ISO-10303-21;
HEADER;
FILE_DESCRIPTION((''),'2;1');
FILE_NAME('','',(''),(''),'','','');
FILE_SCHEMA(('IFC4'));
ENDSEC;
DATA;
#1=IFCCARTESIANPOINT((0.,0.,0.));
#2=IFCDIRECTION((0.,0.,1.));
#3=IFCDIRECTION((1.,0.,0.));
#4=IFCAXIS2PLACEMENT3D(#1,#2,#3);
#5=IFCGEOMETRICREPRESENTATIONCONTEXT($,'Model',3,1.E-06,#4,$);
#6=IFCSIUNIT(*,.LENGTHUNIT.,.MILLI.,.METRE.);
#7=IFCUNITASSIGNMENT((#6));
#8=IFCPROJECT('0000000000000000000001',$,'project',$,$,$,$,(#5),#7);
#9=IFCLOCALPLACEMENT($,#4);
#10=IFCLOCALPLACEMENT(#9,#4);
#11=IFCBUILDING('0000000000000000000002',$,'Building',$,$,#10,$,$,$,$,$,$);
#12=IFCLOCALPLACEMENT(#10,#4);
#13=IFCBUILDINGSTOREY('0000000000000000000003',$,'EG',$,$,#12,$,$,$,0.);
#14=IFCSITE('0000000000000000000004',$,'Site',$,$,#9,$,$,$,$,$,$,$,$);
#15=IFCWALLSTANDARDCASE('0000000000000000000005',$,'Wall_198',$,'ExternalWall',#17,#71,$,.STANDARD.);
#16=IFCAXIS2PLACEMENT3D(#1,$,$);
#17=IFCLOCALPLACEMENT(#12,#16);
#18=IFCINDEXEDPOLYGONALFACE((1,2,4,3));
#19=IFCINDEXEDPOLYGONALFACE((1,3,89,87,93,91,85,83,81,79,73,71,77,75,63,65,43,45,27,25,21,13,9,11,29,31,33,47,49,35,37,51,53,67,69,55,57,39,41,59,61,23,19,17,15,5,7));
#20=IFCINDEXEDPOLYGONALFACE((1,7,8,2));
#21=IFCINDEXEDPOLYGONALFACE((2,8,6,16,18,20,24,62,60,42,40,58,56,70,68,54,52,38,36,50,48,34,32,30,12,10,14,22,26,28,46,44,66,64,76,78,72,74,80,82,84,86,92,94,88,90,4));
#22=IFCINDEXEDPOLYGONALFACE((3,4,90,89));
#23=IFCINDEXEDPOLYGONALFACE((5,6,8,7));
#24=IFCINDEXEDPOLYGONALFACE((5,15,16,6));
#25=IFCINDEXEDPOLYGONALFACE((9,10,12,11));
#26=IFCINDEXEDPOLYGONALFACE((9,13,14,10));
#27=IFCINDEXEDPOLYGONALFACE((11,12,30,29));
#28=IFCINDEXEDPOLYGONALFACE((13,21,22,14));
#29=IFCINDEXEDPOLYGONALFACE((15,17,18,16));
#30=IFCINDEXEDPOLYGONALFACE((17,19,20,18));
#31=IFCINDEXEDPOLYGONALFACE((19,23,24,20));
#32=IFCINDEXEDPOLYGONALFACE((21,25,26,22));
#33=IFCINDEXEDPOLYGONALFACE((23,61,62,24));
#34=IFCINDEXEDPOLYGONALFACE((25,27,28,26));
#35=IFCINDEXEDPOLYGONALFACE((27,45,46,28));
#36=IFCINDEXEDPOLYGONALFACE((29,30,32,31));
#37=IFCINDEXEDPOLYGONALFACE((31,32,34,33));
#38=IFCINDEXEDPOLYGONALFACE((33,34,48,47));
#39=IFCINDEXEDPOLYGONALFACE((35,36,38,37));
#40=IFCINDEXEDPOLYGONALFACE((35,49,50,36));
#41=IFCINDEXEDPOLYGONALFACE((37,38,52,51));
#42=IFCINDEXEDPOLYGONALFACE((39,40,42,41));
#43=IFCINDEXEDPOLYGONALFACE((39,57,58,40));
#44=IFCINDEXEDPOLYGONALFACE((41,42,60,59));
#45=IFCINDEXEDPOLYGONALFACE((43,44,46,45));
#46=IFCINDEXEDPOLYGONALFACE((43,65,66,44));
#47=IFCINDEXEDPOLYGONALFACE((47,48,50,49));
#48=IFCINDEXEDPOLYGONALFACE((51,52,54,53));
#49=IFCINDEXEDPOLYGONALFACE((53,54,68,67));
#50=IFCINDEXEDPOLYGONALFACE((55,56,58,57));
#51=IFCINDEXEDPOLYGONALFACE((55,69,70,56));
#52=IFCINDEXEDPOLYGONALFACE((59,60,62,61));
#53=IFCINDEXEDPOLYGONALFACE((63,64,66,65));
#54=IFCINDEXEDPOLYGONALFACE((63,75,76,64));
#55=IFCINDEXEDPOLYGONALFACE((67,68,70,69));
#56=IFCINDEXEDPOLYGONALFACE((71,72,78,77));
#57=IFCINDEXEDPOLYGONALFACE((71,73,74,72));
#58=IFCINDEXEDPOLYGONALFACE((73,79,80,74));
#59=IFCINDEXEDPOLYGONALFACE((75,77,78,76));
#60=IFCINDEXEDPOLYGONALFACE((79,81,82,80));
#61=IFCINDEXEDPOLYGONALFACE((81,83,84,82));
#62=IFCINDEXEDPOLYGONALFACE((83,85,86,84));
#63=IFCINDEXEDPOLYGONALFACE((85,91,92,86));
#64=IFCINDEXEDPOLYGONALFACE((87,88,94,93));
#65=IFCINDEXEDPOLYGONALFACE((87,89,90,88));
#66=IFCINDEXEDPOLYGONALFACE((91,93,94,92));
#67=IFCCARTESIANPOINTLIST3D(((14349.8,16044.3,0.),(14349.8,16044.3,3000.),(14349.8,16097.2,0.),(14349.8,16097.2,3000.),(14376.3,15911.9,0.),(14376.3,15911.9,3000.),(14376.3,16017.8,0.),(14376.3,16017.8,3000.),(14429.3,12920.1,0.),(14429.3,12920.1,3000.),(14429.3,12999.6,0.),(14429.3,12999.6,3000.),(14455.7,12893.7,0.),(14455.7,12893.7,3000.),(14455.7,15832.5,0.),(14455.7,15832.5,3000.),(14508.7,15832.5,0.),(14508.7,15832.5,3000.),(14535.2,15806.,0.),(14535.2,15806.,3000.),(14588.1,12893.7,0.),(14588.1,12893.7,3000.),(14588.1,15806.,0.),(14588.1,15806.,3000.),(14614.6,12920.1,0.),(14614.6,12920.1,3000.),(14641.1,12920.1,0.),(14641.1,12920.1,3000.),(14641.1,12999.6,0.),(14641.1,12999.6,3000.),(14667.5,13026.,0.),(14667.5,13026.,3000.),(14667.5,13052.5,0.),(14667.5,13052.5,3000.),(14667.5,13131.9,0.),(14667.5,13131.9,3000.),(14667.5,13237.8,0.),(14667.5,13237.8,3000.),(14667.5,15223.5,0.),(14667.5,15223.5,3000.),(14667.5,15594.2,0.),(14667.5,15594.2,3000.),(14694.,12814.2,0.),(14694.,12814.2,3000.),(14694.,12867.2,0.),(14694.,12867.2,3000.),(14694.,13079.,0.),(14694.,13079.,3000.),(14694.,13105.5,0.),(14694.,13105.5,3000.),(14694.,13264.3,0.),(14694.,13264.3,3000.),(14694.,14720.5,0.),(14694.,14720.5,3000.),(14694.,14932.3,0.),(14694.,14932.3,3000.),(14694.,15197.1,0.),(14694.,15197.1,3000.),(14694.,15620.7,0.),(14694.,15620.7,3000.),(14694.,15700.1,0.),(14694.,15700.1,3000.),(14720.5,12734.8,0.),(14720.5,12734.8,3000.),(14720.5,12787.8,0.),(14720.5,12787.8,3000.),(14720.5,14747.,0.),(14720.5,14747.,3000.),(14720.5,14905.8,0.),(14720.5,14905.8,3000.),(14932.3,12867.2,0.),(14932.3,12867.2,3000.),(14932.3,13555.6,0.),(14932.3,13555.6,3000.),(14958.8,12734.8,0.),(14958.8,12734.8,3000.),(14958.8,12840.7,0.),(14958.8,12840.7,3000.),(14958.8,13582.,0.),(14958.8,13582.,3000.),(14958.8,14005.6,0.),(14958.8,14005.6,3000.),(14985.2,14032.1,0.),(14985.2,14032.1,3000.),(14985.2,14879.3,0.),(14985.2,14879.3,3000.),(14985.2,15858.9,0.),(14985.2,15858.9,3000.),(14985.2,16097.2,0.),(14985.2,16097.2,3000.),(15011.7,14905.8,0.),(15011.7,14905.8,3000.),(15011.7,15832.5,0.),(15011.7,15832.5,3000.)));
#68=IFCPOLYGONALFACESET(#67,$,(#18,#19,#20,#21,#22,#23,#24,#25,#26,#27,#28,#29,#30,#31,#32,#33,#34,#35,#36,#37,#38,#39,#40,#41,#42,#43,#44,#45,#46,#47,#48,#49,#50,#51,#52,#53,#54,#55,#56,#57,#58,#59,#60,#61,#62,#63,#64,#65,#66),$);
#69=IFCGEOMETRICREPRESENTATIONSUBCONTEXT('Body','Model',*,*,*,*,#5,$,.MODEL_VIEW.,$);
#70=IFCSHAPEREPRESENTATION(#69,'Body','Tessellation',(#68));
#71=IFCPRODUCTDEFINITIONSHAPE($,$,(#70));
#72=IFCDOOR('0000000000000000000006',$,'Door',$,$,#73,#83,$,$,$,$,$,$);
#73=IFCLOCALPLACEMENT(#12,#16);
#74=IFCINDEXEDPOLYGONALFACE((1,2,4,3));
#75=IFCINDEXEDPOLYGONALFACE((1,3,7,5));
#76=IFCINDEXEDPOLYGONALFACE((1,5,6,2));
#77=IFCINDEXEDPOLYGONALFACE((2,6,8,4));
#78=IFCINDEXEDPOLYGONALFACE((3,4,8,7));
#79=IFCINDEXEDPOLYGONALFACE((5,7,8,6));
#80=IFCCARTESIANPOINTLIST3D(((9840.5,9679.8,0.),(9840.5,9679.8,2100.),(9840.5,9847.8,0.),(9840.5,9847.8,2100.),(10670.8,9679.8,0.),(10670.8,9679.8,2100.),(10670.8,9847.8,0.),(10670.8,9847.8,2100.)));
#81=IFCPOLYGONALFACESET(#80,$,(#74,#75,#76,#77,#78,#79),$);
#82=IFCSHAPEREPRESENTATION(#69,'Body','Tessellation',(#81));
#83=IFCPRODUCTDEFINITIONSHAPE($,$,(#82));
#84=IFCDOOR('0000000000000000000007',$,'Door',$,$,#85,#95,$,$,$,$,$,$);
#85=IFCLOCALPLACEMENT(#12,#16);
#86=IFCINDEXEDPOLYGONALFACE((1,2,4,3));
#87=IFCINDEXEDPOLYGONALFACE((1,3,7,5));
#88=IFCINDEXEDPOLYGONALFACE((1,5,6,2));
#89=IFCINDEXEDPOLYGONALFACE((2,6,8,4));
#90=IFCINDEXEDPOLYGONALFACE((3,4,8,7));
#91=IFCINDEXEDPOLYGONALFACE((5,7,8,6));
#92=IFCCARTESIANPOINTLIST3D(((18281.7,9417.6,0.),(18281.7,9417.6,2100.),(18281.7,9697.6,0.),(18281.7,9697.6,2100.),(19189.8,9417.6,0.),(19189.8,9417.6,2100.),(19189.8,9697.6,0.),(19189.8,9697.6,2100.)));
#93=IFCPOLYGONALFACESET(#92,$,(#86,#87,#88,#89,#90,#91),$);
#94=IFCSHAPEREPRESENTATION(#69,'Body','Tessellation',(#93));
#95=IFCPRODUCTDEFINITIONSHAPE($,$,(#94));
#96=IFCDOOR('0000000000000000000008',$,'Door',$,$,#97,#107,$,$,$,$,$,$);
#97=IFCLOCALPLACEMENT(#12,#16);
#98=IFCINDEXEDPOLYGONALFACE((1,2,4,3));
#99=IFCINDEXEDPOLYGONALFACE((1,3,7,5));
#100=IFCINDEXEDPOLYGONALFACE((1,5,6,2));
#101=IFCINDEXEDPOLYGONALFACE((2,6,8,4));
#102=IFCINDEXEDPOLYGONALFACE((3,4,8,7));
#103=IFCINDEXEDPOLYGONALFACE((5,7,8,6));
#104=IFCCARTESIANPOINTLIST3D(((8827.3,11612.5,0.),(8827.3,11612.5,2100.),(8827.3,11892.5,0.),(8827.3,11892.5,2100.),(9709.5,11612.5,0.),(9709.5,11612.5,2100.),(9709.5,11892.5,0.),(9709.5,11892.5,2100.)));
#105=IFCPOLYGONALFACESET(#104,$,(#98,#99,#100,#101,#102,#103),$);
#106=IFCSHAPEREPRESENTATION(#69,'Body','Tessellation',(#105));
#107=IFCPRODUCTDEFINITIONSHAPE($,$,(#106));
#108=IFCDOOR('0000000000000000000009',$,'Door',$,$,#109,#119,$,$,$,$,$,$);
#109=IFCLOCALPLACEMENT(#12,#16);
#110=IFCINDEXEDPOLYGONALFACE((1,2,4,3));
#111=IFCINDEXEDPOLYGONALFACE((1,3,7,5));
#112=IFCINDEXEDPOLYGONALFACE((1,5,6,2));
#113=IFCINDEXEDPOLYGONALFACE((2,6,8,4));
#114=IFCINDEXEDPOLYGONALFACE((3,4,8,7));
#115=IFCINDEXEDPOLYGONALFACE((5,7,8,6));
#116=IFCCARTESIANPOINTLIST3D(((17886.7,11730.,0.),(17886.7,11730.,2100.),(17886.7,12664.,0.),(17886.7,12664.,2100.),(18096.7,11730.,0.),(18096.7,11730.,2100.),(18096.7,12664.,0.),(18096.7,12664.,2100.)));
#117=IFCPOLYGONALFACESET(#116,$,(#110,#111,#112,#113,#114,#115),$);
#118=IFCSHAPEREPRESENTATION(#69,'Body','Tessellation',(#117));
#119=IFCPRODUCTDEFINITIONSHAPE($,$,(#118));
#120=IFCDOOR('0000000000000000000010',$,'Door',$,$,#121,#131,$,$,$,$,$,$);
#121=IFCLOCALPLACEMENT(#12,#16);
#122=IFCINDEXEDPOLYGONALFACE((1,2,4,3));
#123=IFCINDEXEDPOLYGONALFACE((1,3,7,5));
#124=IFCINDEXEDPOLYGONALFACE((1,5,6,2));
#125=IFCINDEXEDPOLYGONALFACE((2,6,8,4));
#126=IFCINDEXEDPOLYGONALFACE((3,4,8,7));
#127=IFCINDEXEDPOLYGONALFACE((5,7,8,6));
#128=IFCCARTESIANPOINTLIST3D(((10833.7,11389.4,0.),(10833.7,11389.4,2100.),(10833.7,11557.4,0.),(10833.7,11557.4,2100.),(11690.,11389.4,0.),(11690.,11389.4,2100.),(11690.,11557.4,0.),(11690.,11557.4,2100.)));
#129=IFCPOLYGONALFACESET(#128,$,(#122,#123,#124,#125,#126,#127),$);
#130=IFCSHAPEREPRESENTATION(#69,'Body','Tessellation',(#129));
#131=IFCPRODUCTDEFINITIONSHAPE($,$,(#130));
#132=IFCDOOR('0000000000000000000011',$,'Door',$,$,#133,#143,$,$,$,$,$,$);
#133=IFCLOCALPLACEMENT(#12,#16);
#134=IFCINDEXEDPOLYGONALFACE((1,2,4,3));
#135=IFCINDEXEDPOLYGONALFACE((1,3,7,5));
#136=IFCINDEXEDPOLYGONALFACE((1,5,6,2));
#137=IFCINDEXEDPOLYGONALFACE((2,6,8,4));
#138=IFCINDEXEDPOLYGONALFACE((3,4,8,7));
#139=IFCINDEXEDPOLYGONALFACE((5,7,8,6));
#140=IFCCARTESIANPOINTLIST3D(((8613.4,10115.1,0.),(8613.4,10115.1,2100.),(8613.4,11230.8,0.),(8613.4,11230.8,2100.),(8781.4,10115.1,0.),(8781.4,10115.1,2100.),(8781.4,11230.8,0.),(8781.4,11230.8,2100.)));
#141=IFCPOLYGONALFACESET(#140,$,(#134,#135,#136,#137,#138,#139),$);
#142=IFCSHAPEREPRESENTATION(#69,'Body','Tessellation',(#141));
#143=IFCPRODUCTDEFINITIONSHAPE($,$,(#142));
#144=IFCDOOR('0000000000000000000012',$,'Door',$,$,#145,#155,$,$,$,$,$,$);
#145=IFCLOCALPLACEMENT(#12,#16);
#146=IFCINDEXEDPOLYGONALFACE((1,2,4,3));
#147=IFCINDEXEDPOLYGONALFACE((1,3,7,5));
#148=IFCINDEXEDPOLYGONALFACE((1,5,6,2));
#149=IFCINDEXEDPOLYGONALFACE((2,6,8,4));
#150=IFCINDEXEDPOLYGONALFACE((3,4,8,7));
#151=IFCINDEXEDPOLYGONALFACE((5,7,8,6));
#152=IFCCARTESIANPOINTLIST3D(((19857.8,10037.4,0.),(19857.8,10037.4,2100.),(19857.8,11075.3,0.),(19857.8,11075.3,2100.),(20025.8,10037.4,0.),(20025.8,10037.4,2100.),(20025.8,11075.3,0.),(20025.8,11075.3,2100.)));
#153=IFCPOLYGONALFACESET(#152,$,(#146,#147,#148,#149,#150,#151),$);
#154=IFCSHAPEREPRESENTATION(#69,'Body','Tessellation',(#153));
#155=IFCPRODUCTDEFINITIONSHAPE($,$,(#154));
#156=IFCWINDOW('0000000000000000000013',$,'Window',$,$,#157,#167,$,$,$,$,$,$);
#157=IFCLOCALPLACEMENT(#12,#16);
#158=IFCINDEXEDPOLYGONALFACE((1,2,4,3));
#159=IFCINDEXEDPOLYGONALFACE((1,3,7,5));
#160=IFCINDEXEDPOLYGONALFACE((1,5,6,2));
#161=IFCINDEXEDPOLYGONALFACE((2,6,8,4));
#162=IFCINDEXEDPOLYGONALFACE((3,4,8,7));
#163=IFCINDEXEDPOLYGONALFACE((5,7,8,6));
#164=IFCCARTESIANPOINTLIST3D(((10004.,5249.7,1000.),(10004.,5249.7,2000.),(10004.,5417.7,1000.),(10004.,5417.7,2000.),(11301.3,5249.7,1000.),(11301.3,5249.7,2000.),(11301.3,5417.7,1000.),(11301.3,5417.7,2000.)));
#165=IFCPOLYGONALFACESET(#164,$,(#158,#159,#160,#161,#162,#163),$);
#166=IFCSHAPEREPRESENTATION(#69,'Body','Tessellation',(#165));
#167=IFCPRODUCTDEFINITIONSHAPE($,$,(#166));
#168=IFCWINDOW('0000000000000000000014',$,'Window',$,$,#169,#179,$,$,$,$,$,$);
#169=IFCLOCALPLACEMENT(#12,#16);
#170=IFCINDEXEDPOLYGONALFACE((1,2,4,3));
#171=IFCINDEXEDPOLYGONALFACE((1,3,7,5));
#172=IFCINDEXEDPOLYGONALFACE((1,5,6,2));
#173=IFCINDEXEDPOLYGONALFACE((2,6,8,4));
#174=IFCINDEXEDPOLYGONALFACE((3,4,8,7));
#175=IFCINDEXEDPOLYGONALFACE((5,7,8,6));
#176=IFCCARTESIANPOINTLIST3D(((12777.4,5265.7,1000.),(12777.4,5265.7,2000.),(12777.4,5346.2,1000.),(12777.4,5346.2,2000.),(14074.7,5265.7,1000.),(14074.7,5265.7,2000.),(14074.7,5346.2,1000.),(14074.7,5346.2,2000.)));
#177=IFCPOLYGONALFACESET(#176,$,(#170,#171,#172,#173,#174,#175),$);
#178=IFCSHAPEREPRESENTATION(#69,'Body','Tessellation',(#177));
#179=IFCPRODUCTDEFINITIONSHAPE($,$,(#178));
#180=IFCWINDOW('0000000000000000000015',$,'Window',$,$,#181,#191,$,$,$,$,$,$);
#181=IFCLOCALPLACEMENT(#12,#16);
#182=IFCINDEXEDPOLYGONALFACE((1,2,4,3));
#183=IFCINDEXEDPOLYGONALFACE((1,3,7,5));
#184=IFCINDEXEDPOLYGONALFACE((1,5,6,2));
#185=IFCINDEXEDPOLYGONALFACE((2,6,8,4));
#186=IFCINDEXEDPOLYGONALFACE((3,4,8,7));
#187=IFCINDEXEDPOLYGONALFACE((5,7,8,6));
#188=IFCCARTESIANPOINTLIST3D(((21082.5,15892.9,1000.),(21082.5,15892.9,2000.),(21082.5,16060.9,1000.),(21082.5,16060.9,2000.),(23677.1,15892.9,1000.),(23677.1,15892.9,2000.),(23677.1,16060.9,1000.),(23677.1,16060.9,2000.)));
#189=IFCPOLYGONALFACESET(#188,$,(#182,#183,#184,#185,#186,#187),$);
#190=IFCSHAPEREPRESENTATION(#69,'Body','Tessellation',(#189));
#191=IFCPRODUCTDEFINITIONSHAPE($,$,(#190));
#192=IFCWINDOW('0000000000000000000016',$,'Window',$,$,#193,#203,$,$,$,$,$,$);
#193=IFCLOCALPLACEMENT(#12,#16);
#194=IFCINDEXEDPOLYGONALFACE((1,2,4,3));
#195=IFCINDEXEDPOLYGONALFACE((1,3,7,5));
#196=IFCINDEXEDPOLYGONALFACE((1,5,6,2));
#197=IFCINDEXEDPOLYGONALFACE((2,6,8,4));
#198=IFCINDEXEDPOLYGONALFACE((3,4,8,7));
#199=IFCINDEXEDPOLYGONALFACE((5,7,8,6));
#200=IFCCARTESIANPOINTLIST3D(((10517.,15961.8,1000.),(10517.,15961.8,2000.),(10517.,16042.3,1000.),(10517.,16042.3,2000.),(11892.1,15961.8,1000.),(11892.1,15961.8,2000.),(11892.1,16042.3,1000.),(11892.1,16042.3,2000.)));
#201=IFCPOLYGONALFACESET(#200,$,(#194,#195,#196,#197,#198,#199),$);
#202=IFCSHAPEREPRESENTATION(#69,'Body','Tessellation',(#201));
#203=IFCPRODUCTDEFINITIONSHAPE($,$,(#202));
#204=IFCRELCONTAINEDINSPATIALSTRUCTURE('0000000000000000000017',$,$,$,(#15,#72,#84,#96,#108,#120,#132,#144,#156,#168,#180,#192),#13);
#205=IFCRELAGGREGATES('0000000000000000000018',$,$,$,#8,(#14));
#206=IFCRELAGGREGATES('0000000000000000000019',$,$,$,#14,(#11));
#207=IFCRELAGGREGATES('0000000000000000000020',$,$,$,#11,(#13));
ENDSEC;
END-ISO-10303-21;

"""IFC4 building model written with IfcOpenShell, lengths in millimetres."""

from ifc_helpers import new_model, si_unit, frame, origin_with_axes, place, context, subcontext, project, spatial, polyline, rectangle, outline, extrude, element, save


model = new_model("IFC4")

# Units and contexts
model_context = context("Model", 3, precision=1e-06, world=origin_with_axes())
body_context = subcontext(model_context, "Body", "Model", "MODEL_VIEW")
ifc_project = project(units=[si_unit("LENGTHUNIT", "METRE", prefix="MILLI")], contexts=[model_context])

# Site, building, storey
site_placement = place(None, origin_with_axes())
site = spatial("IfcSite", under=ifc_project, at=site_placement, Name="Site")
building_placement = place(site_placement, origin_with_axes())
building = spatial("IfcBuilding", under=site, at=building_placement, Name="Building")
storey_placement = place(building_placement, origin_with_axes())
storey = spatial("IfcBuildingStorey", under=building, at=storey_placement, Name="EG", Elevation=0.0)

# Wall
wall_1_placement = place(storey_placement, origin_with_axes())
element("IfcWallStandardCase", 1, at=wall_1_placement, inside=storey, Name="Wall_198", ObjectType="ExternalWall", PredefinedType="STANDARD", context=body_context, shape_type="SweptSolid", body=[
    extrude(outline(polyline([(14720.5, 12734.8, 0.0), (14720.5, 12787.8, 0.0), (14694.0, 12814.2, 0.0), (14694.0, 12867.2, 0.0), (14641.1, 12920.1, 0.0), (14614.6, 12920.1, 0.0), (14588.1, 12893.7, 0.0), (14455.7, 12893.7, 0.0), (14429.3, 12920.1, 0.0), (14429.3, 12999.6, 0.0), (14641.1, 12999.6, 0.0), (14667.5, 13026.0, 0.0), (14667.5, 13052.5, 0.0), (14694.0, 13079.0, 0.0), (14694.0, 13105.5, 0.0), (14667.5, 13131.9, 0.0), (14667.5, 13237.8, 0.0), (14694.0, 13264.3, 0.0), (14694.0, 14720.5, 0.0), (14720.5, 14747.0, 0.0), (14720.5, 14905.8, 0.0), (14694.0, 14932.3, 0.0), (14694.0, 15197.1, 0.0), (14667.5, 15223.5, 0.0), (14667.5, 15594.2, 0.0), (14694.0, 15620.7, 0.0), (14694.0, 15700.1, 0.0), (14588.1, 15806.0, 0.0), (14535.2, 15806.0, 0.0), (14508.7, 15832.5, 0.0), (14455.7, 15832.5, 0.0), (14376.3, 15911.9, 0.0), (14376.3, 16017.8, 0.0), (14349.8, 16044.3, 0.0), (14349.8, 16097.2, 0.0), (14985.2, 16097.2, 0.0), (14985.2, 15858.9, 0.0), (15011.7, 15832.5, 0.0), (15011.7, 14905.8, 0.0), (14985.2, 14879.3, 0.0), (14985.2, 14032.1, 0.0), (14958.8, 14005.6, 0.0), (14958.8, 13582.0, 0.0), (14932.3, 13555.6, 0.0), (14932.3, 12867.2, 0.0), (14958.8, 12840.7, 0.0), (14958.8, 12734.8, 0.0), (14720.5, 12734.8, 0.0)])), origin_with_axes(), (0.0, 0.0, 1.0), 3000.0),
])

# Doors
door_1_placement = place(storey_placement, origin_with_axes())
element("IfcDoor", 2, at=door_1_placement, inside=storey, Name="Door", context=body_context, shape_type="SweptSolid", body=[
    extrude(rectangle(XDim=830.3, YDim=168.0), frame((10255.6, 9763.8, 0.0), z_axis=(0.0, 0.0, 1.0), x_axis=(1.0, 0.0, 0.0)), (0.0, 0.0, 1.0), 2100.0),
])
door_2_placement = place(storey_placement, origin_with_axes())
element("IfcDoor", 3, at=door_2_placement, inside=storey, Name="Door", context=body_context, shape_type="SweptSolid", body=[
    extrude(rectangle(XDim=908.1, YDim=280.0), frame((18735.7, 9557.6, 0.0), z_axis=(0.0, 0.0, 1.0), x_axis=(1.0, 0.0, 0.0)), (0.0, 0.0, 1.0), 2100.0),
])
door_3_placement = place(storey_placement, origin_with_axes())
element("IfcDoor", 4, at=door_3_placement, inside=storey, Name="Door", context=body_context, shape_type="SweptSolid", body=[
    extrude(rectangle(XDim=882.2, YDim=280.0), frame((9268.4, 11752.5, 0.0), z_axis=(0.0, 0.0, 1.0), x_axis=(1.0, 0.0, 0.0)), (0.0, 0.0, 1.0), 2100.0),
])
door_4_placement = place(storey_placement, origin_with_axes())
element("IfcDoor", 5, at=door_4_placement, inside=storey, Name="Door", context=body_context, shape_type="SweptSolid", body=[
    extrude(rectangle(XDim=934.1, YDim=210.0), frame((17991.7, 12197.0, 0.0), z_axis=(0.0, 0.0, 1.0), x_axis=(0.0, 1.0, 0.0)), (0.0, 0.0, 1.0), 2100.0),
])
door_5_placement = place(storey_placement, origin_with_axes())
element("IfcDoor", 6, at=door_5_placement, inside=storey, Name="Door", context=body_context, shape_type="SweptSolid", body=[
    extrude(rectangle(XDim=856.2, YDim=168.0), frame((11261.9, 11473.4, 0.0), z_axis=(0.0, 0.0, 1.0), x_axis=(1.0, 0.0, 0.0)), (0.0, 0.0, 1.0), 2100.0),
])
door_6_placement = place(storey_placement, origin_with_axes())
element("IfcDoor", 7, at=door_6_placement, inside=storey, Name="Door", context=body_context, shape_type="SweptSolid", body=[
    extrude(rectangle(XDim=1115.7, YDim=168.0), frame((8697.4, 10672.9, 0.0), z_axis=(0.0, 0.0, 1.0), x_axis=(0.0, 1.0, 0.0)), (0.0, 0.0, 1.0), 2100.0),
])
door_7_placement = place(storey_placement, origin_with_axes())
element("IfcDoor", 8, at=door_7_placement, inside=storey, Name="Door", context=body_context, shape_type="SweptSolid", body=[
    extrude(rectangle(XDim=1037.8, YDim=168.0), frame((19941.8, 10556.3, 0.0), z_axis=(0.0, 0.0, 1.0), x_axis=(0.0, 1.0, 0.0)), (0.0, 0.0, 1.0), 2100.0),
])

# Windows
window_1_placement = place(storey_placement, origin_with_axes())
element("IfcWindow", 9, at=window_1_placement, inside=storey, Name="Window", context=body_context, shape_type="SweptSolid", body=[
    extrude(rectangle(XDim=1297.3, YDim=168.0), frame((10652.6, 5333.7, 1000.0), z_axis=(0.0, 0.0, 1.0), x_axis=(1.0, 0.0, 0.0)), (0.0, 0.0, 1.0), 1000.0),
])
window_2_placement = place(storey_placement, origin_with_axes())
element("IfcWindow", 10, at=window_2_placement, inside=storey, Name="Window", context=body_context, shape_type="SweptSolid", body=[
    extrude(rectangle(XDim=1297.3, YDim=80.5), frame((13426.0, 5305.9, 1000.0), z_axis=(0.0, 0.0, 1.0), x_axis=(1.0, 0.0, 0.0)), (0.0, 0.0, 1.0), 1000.0),
])
window_3_placement = place(storey_placement, origin_with_axes())
element("IfcWindow", 11, at=window_3_placement, inside=storey, Name="Window", context=body_context, shape_type="SweptSolid", body=[
    extrude(rectangle(XDim=2594.6, YDim=168.0), frame((22379.8, 15976.9, 1000.0), z_axis=(0.0, 0.0, 1.0), x_axis=(1.0, 0.0, 0.0)), (0.0, 0.0, 1.0), 1000.0),
])
window_4_placement = place(storey_placement, origin_with_axes())
element("IfcWindow", 12, at=window_4_placement, inside=storey, Name="Window", context=body_context, shape_type="SweptSolid", body=[
    extrude(rectangle(XDim=1375.1, YDim=80.5), frame((11204.5, 16002.1, 1000.0), z_axis=(0.0, 0.0, 1.0), x_axis=(1.0, 0.0, 0.0)), (0.0, 0.0, 1.0), 1000.0),
])

save(model, "model.ifc")
